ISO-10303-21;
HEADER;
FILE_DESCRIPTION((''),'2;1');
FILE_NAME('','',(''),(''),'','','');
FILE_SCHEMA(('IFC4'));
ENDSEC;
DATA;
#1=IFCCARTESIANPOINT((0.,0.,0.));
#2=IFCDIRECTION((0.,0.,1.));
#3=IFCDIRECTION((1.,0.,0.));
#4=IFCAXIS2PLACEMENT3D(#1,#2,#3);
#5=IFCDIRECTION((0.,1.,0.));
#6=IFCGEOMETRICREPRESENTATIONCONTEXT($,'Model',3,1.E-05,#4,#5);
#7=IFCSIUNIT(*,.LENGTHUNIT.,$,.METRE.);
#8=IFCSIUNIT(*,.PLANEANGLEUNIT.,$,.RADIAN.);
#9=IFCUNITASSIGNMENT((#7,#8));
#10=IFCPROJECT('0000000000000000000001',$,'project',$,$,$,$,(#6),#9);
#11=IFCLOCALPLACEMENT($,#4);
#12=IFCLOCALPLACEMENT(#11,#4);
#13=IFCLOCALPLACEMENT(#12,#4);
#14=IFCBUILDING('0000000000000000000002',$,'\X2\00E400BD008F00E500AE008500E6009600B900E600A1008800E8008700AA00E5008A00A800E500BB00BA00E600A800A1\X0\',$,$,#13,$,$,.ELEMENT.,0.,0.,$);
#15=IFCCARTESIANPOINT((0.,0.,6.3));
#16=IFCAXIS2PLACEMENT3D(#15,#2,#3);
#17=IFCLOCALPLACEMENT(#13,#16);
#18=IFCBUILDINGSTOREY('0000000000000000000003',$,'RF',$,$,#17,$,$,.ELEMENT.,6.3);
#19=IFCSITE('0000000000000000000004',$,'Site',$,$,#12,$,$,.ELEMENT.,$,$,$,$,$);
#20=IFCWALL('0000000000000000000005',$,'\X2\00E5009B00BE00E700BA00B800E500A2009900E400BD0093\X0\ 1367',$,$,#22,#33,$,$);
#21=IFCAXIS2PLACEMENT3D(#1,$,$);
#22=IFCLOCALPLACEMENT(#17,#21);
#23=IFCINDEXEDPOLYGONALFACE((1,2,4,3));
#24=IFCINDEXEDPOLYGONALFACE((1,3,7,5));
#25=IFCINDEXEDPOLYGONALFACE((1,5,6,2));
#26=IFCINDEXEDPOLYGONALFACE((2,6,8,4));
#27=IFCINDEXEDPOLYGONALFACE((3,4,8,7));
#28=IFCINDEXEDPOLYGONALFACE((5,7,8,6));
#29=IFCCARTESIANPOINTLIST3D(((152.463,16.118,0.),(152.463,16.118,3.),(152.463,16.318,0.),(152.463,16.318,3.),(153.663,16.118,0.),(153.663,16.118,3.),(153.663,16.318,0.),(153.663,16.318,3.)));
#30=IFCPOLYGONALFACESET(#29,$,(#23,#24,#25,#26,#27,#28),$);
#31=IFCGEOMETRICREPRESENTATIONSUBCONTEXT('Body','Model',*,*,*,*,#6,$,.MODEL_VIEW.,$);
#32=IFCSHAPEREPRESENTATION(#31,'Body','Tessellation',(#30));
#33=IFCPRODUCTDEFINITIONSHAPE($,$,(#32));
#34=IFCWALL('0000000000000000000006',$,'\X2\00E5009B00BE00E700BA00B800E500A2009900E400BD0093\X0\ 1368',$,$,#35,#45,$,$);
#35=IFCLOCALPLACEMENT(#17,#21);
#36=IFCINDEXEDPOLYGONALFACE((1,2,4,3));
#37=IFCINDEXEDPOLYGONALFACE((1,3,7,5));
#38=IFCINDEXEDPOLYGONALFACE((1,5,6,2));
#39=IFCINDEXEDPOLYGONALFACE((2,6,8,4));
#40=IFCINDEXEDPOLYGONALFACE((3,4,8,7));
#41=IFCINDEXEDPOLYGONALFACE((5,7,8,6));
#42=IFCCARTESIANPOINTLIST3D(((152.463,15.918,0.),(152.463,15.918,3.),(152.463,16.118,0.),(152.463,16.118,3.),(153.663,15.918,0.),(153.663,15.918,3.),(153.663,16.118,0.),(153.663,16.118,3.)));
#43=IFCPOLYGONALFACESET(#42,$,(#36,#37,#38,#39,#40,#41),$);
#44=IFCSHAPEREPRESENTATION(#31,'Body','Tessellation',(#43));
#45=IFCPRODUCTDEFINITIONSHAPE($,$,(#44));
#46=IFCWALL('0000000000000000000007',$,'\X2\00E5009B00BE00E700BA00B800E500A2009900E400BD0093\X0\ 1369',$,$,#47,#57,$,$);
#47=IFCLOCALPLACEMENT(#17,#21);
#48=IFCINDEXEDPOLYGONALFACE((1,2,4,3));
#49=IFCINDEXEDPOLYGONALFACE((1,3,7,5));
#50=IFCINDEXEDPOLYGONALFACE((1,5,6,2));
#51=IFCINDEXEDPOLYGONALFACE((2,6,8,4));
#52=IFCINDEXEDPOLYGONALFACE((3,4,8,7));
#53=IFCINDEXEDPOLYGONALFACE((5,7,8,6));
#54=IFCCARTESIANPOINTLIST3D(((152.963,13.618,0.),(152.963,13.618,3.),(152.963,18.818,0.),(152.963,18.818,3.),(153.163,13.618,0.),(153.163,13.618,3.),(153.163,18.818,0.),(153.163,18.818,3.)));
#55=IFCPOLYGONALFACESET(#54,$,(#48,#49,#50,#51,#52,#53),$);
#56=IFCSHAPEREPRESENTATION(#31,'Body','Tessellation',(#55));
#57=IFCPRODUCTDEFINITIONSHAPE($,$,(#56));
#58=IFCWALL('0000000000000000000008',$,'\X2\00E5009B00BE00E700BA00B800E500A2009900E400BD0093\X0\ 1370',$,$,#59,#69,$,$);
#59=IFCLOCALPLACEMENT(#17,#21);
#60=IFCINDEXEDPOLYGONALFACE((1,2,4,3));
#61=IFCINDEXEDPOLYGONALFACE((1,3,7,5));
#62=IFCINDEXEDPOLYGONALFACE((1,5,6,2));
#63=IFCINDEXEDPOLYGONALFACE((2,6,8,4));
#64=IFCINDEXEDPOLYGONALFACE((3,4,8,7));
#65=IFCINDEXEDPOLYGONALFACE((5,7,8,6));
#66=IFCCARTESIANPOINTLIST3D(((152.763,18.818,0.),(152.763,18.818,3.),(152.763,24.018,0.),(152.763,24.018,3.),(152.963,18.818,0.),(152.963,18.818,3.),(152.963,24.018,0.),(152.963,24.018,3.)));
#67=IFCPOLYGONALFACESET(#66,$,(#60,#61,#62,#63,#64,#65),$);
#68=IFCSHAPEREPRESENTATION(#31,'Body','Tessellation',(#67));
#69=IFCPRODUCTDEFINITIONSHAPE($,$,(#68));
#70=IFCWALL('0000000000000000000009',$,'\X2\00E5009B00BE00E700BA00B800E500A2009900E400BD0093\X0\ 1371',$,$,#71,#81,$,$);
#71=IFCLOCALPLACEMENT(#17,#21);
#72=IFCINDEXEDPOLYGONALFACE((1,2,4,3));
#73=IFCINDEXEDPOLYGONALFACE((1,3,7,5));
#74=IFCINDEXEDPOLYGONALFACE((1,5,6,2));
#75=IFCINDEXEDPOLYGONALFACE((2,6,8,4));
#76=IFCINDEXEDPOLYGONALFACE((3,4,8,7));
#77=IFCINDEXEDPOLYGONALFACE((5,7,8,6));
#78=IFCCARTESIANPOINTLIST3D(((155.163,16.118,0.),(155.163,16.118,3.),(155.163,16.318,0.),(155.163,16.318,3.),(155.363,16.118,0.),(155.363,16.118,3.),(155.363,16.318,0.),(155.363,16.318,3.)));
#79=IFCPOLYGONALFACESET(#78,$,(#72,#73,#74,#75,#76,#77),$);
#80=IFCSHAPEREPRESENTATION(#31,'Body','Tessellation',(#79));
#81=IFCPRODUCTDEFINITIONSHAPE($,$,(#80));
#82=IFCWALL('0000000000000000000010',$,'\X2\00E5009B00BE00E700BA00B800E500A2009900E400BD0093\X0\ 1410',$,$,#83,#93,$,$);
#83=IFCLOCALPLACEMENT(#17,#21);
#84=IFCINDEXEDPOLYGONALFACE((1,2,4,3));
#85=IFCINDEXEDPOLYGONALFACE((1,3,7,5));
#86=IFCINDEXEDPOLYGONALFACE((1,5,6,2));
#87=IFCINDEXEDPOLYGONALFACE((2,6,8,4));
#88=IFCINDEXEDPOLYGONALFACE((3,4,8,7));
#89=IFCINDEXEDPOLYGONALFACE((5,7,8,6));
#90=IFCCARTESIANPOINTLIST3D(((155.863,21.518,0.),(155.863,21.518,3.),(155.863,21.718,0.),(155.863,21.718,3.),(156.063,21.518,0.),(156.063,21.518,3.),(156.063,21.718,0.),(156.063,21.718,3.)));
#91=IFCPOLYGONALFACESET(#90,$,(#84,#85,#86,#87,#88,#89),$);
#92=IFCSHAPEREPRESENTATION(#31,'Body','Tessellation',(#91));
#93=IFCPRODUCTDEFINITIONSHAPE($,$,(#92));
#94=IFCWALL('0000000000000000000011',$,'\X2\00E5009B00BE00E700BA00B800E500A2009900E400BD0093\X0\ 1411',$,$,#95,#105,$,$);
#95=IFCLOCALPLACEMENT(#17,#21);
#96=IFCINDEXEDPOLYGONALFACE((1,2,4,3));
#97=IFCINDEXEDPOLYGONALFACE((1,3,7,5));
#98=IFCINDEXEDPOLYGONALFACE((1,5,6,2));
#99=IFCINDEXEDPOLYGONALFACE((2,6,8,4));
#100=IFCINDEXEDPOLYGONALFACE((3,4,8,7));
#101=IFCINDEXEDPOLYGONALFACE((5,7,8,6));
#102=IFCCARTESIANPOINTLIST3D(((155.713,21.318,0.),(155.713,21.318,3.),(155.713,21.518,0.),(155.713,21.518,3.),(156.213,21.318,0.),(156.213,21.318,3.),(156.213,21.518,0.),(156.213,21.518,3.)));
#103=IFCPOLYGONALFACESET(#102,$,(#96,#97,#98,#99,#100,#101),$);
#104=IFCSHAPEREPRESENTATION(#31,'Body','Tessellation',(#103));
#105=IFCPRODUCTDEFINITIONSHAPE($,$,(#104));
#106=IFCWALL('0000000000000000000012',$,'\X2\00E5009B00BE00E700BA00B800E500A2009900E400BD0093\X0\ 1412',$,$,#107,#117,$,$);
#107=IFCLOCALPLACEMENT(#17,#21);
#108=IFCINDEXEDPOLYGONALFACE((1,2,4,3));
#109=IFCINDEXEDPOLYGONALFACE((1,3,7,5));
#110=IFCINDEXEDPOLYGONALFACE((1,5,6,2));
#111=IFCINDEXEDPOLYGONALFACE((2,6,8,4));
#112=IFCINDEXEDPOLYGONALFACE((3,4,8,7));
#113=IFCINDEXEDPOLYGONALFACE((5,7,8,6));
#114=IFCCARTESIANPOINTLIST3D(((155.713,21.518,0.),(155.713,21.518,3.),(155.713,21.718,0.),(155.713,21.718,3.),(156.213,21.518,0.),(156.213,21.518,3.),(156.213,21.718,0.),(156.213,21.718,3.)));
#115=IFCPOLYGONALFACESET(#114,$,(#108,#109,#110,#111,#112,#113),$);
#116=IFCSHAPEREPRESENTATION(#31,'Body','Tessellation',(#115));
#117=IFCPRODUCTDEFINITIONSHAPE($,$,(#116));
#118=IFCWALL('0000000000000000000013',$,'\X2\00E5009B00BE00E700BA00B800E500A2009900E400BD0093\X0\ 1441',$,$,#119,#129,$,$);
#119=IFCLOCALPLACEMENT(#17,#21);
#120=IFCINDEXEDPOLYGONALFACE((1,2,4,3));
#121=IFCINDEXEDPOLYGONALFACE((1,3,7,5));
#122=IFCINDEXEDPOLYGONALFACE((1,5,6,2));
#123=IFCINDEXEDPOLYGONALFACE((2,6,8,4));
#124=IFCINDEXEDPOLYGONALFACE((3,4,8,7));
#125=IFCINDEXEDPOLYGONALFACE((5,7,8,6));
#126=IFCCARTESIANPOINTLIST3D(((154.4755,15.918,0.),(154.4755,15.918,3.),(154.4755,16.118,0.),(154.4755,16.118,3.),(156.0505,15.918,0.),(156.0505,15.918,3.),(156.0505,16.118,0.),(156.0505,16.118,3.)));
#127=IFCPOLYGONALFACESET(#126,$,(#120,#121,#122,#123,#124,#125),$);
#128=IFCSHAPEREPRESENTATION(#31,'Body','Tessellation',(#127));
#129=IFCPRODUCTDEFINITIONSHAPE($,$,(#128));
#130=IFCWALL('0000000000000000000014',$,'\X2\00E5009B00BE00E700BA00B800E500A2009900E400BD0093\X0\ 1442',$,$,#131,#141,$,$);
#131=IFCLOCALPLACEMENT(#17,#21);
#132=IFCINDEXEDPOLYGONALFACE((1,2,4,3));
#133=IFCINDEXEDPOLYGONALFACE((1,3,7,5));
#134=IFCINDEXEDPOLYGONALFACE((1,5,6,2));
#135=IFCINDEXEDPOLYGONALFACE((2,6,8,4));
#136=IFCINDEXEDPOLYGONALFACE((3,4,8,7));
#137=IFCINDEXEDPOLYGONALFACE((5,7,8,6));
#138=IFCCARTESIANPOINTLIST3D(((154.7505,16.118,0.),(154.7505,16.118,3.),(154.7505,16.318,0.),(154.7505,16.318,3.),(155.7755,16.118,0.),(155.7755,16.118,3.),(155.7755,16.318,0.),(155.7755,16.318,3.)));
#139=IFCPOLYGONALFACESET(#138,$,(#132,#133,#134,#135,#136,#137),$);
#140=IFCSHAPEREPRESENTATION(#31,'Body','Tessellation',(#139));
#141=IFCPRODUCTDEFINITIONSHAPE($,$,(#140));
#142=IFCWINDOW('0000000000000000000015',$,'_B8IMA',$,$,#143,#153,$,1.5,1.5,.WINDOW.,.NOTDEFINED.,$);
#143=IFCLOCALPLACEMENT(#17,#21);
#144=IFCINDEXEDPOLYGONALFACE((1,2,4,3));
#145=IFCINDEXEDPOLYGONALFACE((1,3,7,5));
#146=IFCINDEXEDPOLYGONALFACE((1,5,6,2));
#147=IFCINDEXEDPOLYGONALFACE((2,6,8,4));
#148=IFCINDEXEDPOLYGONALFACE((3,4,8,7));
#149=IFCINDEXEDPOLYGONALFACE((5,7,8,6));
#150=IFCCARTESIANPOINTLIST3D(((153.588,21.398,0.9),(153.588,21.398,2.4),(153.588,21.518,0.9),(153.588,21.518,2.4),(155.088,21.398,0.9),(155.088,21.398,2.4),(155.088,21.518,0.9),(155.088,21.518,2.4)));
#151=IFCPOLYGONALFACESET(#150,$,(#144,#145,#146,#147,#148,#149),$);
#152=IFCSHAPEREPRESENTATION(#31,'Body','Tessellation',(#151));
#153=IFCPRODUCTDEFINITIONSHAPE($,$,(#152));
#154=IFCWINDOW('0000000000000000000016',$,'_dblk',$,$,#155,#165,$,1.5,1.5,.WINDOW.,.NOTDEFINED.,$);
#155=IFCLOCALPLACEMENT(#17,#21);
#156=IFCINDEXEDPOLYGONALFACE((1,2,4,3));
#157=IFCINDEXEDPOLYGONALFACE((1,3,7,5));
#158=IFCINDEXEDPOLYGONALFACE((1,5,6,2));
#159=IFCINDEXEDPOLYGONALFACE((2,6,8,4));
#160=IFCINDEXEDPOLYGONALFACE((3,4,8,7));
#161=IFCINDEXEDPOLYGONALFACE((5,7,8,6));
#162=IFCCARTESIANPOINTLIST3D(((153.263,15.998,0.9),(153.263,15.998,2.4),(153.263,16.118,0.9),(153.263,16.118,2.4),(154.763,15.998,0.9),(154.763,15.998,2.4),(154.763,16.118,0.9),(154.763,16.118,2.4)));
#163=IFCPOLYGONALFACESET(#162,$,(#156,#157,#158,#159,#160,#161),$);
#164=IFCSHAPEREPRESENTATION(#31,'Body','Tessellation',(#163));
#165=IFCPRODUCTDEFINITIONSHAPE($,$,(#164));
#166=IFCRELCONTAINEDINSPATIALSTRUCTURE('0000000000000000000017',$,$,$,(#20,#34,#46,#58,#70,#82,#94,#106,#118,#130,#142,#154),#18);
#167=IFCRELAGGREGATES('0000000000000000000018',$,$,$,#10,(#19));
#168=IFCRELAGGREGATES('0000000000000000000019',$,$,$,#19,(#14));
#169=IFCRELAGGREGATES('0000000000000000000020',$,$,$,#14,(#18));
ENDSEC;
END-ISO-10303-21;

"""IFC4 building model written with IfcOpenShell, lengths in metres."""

from ifc_helpers import new_model, si_unit, direction, frame, frame_2d, origin_with_axes, place, context, subcontext, project, spatial, rectangle, extrude, element, save


model = new_model("IFC4")

# Units and contexts
model_context = context("Model", 3, precision=1e-05, world=origin_with_axes(), true_north=direction((0.0, 1.0, 0.0)))
body_context = subcontext(model_context, "Body", "Model", "MODEL_VIEW")
ifc_project = project(units=[si_unit("LENGTHUNIT", "METRE"), si_unit("PLANEANGLEUNIT", "RADIAN")], contexts=[model_context])

# Site, building, storey
placement = place(None, origin_with_axes())
site_placement = place(placement, origin_with_axes())
site = spatial("IfcSite", under=ifc_project, at=site_placement, Name="Site", CompositionType="ELEMENT")
building_placement = place(site_placement, origin_with_axes())
building = spatial("IfcBuilding", under=site, at=building_placement, Name="ä½\u008få®\u0085æ\u0096¹æ¡\u0088è\u0087ªå\u008a¨å»ºæ¨¡", CompositionType="ELEMENT", ElevationOfRefHeight=0.0, ElevationOfTerrain=0.0)
storey_placement = place(building_placement, frame((0.0, 0.0, 6.3), z_axis=(0.0, 0.0, 1.0), x_axis=(1.0, 0.0, 0.0)))
storey = spatial("IfcBuildingStorey", under=building, at=storey_placement, Name="RF", CompositionType="ELEMENT", Elevation=6.3)

# Walls
for number, where, z_axis, x_axis, name in (
    (1, (153.063, 16.218, 0.0), (0.0, 0.0, 1.0), (1.0, 0.0, 0.0), "å\u009b¾çº¸å¢\u0099ä½\u0093 1367"),
    (2, (153.063, 16.018, 0.0), (0.0, 0.0, 1.0), (1.0, 0.0, 0.0), "å\u009b¾çº¸å¢\u0099ä½\u0093 1368"),
):
    element("IfcWall", number, at=place(storey_placement, frame(where, z_axis=z_axis, x_axis=x_axis)), inside=storey, Name=name, context=body_context, shape_type="SweptSolid", body=[
        extrude(rectangle(XDim=1.2, YDim=0.2, at=frame_2d((0.0, 0.0), x_axis=(1.0, 0.0, 0.0))), frame((0.0, 0.0, 0.0), z_axis=(0.0, 0.0, 1.0)), (0.0, 0.0, 1.0), 3.0),
    ])
for number, where, z_axis, x_axis, name in (
    (3, (153.063, 16.218, 0.0), (0.0, 0.0, 1.0), (0.0, 1.0, 0.0), "å\u009b¾çº¸å¢\u0099ä½\u0093 1369"),
    (4, (152.863, 21.418, 0.0), (0.0, 0.0, 1.0), (0.0, -1.0, 0.0), "å\u009b¾çº¸å¢\u0099ä½\u0093 1370"),
):
    element("IfcWall", number, at=place(storey_placement, frame(where, z_axis=z_axis, x_axis=x_axis)), inside=storey, Name=name, context=body_context, shape_type="SweptSolid", body=[
        extrude(rectangle(XDim=5.2, YDim=0.2, at=frame_2d((0.0, 0.0), x_axis=(1.0, 0.0, 0.0))), frame((0.0, 0.0, 0.0), z_axis=(0.0, 0.0, 1.0)), (0.0, 0.0, 1.0), 3.0),
    ])
for number, where, z_axis, x_axis, name in (
    (5, (155.263, 16.218, 0.0), (0.0, 0.0, 1.0), (0.0, -1.0, 0.0), "å\u009b¾çº¸å¢\u0099ä½\u0093 1371"),
    (6, (155.963, 21.618, 0.0), (0.0, 0.0, 1.0), (0.0, -1.0, 0.0), "å\u009b¾çº¸å¢\u0099ä½\u0093 1410"),
):
    element("IfcWall", number, at=place(storey_placement, frame(where, z_axis=z_axis, x_axis=x_axis)), inside=storey, Name=name, context=body_context, shape_type="SweptSolid", body=[
        extrude(rectangle(XDim=0.2, YDim=0.2, at=frame_2d((0.0, 0.0), x_axis=(1.0, 0.0, 0.0))), frame((0.0, 0.0, 0.0), z_axis=(0.0, 0.0, 1.0)), (0.0, 0.0, 1.0), 3.0),
    ])
for number, where, z_axis, x_axis, name in (
    (7, (155.963, 21.418, 0.0), (0.0, 0.0, 1.0), (1.0, 0.0, 0.0), "å\u009b¾çº¸å¢\u0099ä½\u0093 1411"),
    (8, (155.963, 21.618, 0.0), (0.0, 0.0, 1.0), (1.0, 0.0, 0.0), "å\u009b¾çº¸å¢\u0099ä½\u0093 1412"),
):
    element("IfcWall", number, at=place(storey_placement, frame(where, z_axis=z_axis, x_axis=x_axis)), inside=storey, Name=name, context=body_context, shape_type="SweptSolid", body=[
        extrude(rectangle(XDim=0.5, YDim=0.2, at=frame_2d((0.0, 0.0), x_axis=(1.0, 0.0, 0.0))), frame((0.0, 0.0, 0.0), z_axis=(0.0, 0.0, 1.0)), (0.0, 0.0, 1.0), 3.0),
    ])
wall_1_placement = place(storey_placement, frame((155.263, 16.018, 0.0), z_axis=(0.0, 0.0, 1.0), x_axis=(1.0, 0.0, 0.0)))
element("IfcWall", 9, at=wall_1_placement, inside=storey, Name="å\u009b¾çº¸å¢\u0099ä½\u0093 1441", context=body_context, shape_type="SweptSolid", body=[
    extrude(rectangle(XDim=1.575, YDim=0.2, at=frame_2d((0.0, 0.0), x_axis=(1.0, 0.0, 0.0))), frame((0.0, 0.0, 0.0), z_axis=(0.0, 0.0, 1.0)), (0.0, 0.0, 1.0), 3.0),
])
wall_2_placement = place(storey_placement, frame((155.263, 16.218, 0.0), z_axis=(0.0, 0.0, 1.0), x_axis=(1.0, 0.0, 0.0)))
element("IfcWall", 10, at=wall_2_placement, inside=storey, Name="å\u009b¾çº¸å¢\u0099ä½\u0093 1442", context=body_context, shape_type="SweptSolid", body=[
    extrude(rectangle(XDim=1.025, YDim=0.2, at=frame_2d((0.0, 0.0), x_axis=(1.0, 0.0, 0.0))), frame((0.0, 0.0, 0.0), z_axis=(0.0, 0.0, 1.0)), (0.0, 0.0, 1.0), 3.0),
])

# Windows
for number, where, z_axis, x_axis, name in (
    (11, (154.338, 21.458, 0.9), (0.0, 0.0, 1.0), (1.0, 0.0, 0.0), "_B8IMA"),
    (12, (154.013, 16.058, 0.9), (0.0, 0.0, 1.0), (1.0, 0.0, 0.0), "_dblk"),
):
    element("IfcWindow", number, at=place(storey_placement, frame(where, z_axis=z_axis, x_axis=x_axis)), inside=storey, Name=name, OverallHeight=1.5, OverallWidth=1.5, PartitioningType="NOTDEFINED", PredefinedType="WINDOW", context=body_context, shape_type="SweptSolid", body=[
        extrude(rectangle(XDim=1.5, YDim=0.12, at=frame_2d((0.0, 0.0), x_axis=(1.0, 0.0, 0.0))), frame((0.0, 0.0, 0.0), z_axis=(0.0, 0.0, 1.0)), (0.0, 0.0, 1.0), 1.5),
    ])

save(model, "model.ifc")
